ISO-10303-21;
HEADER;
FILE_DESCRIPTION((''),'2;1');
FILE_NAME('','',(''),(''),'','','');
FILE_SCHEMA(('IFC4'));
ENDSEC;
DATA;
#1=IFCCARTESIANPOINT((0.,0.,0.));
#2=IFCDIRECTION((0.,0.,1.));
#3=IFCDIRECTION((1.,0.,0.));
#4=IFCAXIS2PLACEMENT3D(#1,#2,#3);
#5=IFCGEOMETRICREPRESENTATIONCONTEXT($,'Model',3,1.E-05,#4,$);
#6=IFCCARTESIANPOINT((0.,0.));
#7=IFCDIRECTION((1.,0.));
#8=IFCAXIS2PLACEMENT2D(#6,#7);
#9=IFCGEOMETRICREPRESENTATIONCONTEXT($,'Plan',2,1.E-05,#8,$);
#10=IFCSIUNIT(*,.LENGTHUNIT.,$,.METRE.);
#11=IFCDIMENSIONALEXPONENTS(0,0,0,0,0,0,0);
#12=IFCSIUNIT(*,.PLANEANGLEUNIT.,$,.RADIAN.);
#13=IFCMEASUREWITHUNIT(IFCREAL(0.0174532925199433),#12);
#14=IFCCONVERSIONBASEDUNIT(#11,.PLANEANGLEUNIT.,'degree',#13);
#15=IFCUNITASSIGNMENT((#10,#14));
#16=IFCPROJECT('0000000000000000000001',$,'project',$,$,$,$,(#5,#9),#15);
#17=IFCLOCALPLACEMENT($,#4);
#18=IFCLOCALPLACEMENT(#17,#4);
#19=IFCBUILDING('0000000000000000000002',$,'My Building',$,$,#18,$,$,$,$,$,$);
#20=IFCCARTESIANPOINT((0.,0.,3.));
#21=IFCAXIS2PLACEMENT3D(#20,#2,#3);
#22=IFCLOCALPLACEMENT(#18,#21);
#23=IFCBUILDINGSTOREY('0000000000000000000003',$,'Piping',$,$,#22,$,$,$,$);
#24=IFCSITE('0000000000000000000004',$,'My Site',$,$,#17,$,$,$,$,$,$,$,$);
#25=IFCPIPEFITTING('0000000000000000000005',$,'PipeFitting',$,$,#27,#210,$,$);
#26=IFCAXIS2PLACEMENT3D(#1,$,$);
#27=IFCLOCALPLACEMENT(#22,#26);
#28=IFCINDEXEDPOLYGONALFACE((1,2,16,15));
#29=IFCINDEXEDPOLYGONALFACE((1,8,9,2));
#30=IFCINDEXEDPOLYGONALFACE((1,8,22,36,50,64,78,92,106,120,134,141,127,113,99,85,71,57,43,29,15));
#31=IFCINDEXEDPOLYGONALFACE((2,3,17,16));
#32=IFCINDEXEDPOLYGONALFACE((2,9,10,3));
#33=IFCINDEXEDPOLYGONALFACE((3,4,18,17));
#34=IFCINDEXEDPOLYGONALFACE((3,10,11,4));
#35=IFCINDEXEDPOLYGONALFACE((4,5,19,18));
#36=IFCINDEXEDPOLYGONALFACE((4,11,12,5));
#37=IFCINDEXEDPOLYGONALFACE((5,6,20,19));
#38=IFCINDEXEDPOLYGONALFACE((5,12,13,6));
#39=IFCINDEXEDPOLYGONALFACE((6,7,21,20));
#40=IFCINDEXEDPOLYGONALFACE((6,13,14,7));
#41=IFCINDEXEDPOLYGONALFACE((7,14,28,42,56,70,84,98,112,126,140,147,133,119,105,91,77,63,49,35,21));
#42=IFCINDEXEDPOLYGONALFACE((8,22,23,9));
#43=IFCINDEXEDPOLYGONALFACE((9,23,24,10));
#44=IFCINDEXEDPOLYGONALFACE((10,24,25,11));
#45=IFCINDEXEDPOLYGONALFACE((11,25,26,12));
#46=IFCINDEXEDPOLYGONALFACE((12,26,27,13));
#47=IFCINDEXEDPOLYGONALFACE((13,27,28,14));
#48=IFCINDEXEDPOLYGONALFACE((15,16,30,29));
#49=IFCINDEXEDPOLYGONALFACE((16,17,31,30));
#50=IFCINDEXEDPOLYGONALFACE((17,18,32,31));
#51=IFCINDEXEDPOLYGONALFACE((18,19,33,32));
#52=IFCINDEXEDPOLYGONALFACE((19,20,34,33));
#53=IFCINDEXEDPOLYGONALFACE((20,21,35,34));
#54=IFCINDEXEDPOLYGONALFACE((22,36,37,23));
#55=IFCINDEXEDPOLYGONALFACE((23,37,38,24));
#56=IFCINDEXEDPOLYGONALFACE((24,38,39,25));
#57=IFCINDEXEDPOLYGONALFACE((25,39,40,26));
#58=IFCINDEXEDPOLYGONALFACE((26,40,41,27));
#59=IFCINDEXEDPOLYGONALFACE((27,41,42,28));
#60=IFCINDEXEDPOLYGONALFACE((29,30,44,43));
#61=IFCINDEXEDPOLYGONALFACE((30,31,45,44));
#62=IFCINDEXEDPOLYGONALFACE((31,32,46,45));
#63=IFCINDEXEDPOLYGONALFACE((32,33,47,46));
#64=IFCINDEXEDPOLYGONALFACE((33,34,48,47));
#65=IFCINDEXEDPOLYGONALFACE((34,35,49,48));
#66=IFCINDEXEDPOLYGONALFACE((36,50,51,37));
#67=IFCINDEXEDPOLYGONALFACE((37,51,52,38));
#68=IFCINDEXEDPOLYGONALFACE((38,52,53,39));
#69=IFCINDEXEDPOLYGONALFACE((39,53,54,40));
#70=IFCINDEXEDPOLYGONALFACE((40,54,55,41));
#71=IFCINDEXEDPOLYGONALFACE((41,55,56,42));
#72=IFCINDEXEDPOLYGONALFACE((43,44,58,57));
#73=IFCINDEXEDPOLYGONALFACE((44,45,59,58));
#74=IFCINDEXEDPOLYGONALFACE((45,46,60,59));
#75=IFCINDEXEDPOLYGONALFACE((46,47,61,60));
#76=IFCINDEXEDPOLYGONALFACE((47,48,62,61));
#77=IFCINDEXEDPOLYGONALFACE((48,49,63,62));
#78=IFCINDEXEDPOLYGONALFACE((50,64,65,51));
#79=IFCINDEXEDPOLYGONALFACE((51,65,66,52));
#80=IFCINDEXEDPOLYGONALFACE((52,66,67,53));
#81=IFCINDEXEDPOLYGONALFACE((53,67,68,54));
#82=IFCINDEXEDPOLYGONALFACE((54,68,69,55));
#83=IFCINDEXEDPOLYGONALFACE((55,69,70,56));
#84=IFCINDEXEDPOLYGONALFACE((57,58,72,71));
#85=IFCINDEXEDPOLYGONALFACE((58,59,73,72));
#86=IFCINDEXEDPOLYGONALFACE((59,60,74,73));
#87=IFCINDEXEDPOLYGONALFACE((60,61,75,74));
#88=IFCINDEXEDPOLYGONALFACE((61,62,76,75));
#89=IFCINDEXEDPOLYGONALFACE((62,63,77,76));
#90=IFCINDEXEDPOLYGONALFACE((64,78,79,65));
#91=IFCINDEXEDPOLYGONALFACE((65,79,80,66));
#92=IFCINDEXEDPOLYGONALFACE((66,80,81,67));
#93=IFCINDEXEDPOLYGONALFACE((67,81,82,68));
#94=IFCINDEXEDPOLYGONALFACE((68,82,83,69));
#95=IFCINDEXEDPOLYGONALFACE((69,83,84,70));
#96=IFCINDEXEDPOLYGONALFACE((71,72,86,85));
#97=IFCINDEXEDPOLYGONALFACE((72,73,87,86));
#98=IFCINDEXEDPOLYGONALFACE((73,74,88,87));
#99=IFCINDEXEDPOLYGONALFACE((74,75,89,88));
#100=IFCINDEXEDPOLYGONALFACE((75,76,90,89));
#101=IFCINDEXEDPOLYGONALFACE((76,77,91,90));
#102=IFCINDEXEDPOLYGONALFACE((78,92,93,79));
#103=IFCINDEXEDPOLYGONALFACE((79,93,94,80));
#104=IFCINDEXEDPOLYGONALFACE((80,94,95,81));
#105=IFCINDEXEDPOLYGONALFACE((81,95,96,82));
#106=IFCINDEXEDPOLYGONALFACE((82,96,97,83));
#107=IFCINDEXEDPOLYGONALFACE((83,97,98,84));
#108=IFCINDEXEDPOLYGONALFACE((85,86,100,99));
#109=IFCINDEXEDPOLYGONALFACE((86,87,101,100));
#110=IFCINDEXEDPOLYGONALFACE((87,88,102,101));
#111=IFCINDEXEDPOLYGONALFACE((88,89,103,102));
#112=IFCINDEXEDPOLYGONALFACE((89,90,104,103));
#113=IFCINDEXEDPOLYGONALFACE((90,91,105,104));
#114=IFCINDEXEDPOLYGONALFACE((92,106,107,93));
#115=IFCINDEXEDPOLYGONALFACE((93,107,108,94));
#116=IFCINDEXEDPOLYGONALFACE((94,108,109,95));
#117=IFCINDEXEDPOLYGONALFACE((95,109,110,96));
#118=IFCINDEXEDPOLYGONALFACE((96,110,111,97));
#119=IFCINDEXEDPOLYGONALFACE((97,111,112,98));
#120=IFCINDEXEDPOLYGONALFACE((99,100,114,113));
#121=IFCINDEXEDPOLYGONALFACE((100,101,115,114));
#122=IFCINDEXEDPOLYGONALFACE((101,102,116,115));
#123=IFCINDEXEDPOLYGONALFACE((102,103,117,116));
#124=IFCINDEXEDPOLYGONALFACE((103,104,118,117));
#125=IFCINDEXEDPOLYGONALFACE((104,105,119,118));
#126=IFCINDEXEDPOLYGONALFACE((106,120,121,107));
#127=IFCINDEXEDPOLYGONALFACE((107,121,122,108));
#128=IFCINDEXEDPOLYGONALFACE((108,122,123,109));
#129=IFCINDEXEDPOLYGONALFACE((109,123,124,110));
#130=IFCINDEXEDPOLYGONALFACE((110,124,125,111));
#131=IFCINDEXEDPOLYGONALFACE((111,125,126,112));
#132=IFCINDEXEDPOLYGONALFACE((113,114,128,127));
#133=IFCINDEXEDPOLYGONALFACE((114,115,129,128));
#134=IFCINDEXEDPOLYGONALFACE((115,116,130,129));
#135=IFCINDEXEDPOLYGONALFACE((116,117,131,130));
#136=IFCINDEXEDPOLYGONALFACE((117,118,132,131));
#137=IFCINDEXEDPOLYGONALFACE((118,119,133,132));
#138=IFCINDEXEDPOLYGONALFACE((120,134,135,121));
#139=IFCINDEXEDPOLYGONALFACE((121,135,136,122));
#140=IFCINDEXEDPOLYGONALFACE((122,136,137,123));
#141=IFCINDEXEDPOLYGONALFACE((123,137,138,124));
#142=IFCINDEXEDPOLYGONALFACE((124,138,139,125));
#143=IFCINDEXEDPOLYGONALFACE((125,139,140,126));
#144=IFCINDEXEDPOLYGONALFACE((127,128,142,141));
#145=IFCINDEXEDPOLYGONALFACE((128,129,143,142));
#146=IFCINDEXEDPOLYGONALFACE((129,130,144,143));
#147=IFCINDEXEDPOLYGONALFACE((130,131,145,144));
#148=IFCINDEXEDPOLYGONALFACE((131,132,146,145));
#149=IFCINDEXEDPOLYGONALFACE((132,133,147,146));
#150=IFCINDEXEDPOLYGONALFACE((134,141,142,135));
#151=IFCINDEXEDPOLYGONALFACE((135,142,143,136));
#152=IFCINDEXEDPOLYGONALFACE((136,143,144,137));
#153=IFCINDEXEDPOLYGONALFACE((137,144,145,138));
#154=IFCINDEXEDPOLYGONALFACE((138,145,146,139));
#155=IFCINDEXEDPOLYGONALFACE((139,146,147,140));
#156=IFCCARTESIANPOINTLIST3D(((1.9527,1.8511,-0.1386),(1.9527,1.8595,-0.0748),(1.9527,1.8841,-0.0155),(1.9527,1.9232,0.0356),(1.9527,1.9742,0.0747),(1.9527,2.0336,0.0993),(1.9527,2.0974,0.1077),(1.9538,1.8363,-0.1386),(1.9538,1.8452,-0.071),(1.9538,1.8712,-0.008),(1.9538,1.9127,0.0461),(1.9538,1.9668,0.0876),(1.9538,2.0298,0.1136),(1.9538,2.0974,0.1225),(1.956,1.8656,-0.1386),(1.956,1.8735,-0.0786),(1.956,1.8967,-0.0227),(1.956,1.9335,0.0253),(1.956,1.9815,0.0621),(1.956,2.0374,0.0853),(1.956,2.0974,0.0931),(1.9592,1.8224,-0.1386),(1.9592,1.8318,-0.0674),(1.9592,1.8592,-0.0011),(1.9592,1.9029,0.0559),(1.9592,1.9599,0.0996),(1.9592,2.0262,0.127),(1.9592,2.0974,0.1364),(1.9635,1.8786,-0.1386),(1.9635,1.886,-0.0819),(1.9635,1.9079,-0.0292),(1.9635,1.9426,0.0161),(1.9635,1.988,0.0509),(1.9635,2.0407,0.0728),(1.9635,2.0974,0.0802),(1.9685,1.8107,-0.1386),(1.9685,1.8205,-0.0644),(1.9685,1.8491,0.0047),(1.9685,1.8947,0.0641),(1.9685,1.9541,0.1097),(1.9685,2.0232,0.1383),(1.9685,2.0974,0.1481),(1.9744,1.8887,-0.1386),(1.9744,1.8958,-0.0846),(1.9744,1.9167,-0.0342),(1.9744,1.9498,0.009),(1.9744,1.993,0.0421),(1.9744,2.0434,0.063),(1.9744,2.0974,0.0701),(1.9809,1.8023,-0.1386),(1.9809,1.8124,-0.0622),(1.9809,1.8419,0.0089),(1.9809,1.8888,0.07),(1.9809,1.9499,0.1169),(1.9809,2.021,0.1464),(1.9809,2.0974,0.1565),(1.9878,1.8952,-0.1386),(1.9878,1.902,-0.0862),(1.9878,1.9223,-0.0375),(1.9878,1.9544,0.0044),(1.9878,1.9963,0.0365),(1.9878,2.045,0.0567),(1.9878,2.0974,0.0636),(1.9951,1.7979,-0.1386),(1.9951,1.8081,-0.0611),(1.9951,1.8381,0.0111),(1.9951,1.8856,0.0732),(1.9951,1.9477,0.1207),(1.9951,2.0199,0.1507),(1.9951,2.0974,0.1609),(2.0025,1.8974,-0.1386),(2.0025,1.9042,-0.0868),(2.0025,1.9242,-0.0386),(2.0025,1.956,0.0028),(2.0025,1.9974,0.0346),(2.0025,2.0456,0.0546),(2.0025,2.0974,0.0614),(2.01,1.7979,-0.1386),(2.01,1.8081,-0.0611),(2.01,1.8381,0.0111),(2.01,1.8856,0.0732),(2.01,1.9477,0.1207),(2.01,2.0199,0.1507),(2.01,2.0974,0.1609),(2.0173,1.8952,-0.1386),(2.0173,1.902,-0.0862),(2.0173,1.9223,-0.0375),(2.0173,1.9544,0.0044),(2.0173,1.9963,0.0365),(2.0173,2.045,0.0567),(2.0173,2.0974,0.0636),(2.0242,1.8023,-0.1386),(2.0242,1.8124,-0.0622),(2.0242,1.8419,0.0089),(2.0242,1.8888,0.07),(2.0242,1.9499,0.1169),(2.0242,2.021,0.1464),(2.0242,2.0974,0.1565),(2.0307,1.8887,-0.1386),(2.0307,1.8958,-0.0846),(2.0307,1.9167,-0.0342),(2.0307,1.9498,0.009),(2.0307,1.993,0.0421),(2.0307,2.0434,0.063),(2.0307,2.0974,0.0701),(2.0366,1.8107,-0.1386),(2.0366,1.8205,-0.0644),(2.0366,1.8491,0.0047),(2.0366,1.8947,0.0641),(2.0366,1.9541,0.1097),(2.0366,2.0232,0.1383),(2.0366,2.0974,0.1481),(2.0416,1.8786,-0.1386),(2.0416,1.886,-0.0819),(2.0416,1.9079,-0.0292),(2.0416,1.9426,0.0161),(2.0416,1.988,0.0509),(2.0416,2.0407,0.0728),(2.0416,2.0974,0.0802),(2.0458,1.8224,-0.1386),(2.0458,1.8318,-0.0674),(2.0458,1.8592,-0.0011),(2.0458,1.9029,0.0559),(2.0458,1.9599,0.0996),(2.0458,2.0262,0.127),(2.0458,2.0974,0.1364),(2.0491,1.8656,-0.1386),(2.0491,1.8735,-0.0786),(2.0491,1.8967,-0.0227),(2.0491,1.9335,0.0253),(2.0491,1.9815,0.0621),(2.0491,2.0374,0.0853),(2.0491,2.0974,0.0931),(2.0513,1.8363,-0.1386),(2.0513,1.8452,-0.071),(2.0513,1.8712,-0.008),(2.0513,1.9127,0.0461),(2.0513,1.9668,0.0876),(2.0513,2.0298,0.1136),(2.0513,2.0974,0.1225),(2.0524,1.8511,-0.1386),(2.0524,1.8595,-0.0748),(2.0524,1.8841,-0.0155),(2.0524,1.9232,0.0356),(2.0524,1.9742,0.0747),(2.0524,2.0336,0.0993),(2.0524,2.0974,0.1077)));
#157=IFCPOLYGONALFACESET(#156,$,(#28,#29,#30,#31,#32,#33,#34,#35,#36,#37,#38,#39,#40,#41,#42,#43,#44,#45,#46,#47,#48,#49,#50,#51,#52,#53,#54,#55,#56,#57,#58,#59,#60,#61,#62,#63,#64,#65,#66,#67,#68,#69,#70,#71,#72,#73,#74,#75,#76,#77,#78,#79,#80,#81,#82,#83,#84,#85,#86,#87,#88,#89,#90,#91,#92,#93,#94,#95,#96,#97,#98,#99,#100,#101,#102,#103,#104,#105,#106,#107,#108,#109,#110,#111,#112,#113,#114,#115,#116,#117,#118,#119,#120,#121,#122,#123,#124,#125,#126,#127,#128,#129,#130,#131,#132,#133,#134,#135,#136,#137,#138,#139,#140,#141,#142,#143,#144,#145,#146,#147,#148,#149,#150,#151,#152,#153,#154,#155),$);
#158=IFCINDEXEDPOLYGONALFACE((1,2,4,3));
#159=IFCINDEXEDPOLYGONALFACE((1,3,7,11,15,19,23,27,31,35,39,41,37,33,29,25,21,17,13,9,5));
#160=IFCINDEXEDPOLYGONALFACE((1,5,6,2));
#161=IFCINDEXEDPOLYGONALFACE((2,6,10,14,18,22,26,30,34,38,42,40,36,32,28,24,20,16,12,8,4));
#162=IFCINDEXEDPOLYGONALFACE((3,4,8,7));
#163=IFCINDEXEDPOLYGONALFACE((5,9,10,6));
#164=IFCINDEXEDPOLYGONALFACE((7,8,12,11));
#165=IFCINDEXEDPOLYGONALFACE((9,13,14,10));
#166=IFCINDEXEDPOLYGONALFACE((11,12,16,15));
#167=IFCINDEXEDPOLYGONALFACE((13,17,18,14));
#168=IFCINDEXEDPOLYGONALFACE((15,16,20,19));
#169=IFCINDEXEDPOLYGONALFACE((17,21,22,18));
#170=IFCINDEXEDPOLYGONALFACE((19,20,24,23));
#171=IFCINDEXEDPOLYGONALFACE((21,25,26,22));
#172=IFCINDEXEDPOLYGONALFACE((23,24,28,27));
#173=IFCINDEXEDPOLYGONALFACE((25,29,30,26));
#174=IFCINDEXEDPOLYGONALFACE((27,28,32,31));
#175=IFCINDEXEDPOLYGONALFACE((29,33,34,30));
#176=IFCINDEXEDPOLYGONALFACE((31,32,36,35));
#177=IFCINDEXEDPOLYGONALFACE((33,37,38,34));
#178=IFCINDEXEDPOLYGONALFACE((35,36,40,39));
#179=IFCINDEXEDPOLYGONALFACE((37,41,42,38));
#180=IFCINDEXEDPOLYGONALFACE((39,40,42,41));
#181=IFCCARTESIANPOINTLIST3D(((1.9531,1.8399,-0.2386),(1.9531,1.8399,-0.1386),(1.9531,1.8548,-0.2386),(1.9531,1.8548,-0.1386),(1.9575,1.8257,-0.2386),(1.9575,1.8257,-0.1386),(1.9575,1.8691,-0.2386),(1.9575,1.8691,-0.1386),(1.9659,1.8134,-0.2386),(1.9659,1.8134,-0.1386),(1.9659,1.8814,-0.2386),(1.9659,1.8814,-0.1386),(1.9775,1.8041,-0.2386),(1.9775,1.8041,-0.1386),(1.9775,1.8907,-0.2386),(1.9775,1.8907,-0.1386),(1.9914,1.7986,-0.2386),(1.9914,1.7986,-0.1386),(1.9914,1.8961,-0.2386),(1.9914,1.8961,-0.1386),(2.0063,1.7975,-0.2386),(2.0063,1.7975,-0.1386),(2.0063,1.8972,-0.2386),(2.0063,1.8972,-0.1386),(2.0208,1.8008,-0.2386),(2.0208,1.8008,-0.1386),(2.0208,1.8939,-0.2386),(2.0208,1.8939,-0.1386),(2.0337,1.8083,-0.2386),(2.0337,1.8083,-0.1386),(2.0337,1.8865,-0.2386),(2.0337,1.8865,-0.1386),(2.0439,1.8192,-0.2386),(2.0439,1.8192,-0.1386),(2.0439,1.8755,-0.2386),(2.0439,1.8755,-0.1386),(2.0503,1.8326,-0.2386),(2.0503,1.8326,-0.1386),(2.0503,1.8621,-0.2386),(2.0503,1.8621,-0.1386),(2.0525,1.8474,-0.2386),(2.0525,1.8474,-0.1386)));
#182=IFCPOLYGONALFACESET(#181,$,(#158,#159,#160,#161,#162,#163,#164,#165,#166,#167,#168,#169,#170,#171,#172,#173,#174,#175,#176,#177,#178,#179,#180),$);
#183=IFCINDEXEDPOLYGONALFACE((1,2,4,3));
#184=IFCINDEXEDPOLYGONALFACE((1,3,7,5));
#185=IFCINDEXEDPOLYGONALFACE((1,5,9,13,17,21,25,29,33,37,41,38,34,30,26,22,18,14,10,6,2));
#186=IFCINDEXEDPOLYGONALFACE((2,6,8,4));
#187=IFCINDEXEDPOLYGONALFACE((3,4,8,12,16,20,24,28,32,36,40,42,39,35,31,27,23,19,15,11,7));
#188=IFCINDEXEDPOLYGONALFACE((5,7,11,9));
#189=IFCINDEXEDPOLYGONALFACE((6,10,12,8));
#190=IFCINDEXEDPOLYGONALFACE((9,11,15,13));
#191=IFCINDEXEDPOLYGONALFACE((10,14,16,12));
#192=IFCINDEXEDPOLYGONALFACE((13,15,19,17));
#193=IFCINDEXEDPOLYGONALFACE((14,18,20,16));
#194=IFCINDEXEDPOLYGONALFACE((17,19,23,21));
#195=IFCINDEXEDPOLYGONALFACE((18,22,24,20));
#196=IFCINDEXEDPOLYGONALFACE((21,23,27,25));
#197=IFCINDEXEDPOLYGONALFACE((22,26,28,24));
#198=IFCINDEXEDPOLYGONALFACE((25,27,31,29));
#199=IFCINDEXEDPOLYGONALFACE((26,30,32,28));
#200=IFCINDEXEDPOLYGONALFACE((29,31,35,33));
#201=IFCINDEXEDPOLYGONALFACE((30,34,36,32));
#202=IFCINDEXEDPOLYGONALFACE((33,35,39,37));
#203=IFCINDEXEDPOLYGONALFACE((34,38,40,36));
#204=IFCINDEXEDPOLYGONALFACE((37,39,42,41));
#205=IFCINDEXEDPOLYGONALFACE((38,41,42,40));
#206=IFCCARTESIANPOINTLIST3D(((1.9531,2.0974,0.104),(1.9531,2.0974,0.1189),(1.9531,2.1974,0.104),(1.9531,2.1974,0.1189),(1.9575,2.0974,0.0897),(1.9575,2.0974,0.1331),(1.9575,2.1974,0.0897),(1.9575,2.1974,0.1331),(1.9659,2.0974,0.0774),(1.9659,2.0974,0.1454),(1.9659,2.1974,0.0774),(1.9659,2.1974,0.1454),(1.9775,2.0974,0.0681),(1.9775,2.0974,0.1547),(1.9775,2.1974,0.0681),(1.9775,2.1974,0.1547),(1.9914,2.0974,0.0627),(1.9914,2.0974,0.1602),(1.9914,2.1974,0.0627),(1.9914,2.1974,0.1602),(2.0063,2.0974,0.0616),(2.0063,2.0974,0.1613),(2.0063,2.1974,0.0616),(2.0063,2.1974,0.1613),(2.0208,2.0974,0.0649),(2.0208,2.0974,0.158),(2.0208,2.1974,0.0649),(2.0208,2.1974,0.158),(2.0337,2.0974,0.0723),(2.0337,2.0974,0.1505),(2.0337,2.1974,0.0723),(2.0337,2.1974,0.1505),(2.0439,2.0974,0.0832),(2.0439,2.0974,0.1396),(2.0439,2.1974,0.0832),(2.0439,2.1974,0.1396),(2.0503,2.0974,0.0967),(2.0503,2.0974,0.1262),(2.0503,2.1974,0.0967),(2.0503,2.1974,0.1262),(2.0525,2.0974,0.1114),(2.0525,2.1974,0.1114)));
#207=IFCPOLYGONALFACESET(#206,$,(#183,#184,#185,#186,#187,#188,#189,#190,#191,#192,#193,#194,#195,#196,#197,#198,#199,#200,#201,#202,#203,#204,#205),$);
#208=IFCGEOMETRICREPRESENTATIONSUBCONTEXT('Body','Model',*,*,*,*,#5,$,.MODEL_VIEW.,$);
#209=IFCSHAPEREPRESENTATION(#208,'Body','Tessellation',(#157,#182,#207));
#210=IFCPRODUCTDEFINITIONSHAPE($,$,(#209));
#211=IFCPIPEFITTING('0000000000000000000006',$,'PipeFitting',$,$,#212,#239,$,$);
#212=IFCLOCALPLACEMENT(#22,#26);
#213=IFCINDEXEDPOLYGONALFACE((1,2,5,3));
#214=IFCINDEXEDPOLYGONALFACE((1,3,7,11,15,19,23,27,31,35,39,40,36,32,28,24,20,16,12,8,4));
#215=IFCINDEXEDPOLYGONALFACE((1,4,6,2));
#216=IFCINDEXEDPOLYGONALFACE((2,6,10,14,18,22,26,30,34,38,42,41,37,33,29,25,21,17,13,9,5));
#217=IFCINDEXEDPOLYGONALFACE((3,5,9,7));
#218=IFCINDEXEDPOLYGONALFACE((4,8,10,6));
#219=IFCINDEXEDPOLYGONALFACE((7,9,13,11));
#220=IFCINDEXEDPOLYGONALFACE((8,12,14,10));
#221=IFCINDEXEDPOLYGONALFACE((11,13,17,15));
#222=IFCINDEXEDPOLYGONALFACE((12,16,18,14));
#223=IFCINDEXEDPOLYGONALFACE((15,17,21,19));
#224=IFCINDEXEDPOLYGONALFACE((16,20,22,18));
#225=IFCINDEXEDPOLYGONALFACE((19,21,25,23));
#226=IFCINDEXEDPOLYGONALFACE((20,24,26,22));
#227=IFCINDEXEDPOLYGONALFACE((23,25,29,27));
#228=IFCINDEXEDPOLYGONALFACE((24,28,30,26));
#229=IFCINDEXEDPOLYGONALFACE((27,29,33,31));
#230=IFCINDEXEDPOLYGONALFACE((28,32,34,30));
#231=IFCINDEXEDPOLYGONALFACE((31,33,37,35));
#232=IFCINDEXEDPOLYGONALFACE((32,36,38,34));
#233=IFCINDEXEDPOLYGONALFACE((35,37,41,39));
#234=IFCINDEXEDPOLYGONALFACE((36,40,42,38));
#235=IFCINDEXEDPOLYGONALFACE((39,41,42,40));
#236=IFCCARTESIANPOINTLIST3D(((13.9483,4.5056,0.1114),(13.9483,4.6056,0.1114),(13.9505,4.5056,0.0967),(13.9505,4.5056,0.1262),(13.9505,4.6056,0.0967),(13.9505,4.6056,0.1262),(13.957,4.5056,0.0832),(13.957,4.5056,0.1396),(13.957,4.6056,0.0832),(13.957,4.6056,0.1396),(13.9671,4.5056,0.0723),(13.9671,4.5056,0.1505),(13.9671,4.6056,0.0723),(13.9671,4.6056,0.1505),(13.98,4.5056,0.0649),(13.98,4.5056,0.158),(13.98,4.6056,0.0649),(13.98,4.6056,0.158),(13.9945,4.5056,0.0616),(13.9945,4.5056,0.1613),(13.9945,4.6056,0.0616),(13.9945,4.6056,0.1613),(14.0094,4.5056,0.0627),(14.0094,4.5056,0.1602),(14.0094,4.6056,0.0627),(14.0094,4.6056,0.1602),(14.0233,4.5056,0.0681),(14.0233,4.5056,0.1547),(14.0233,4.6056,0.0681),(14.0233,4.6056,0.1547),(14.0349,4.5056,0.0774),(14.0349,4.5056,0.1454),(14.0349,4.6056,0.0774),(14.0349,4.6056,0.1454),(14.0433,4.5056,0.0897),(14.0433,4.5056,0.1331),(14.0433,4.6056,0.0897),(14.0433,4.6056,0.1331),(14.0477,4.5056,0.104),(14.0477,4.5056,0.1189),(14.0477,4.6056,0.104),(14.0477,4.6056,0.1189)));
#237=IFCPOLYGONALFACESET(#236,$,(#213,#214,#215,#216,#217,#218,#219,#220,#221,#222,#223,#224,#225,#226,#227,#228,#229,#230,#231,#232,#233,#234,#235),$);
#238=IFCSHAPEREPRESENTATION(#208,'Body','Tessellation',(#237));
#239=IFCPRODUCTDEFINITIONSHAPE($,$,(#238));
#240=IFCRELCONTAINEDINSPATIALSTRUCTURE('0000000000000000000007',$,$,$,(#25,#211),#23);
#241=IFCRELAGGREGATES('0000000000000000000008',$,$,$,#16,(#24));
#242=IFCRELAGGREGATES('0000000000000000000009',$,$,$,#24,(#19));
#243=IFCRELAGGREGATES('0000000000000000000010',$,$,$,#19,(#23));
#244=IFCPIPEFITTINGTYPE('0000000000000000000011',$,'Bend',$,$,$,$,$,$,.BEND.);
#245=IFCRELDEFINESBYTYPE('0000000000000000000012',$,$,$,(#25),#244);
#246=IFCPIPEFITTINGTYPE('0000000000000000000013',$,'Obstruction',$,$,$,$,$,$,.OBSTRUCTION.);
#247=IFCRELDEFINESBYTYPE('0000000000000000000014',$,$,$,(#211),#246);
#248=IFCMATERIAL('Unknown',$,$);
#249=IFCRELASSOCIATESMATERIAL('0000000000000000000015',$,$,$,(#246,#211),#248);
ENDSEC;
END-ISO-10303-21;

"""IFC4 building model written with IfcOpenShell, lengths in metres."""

from ifc_helpers import new_model, entity, si_unit, converted_unit, frame, origin_with_axes, origin_2d_with_axis, place, context, subcontext, project, spatial, circle, extrude, source, transform, mapped, material, material_profile, profile_set, profile_usage, type_object, type_shapes, element, save


model = new_model("IFC4")

# Units and contexts
model_context = context("Model", 3, precision=1e-05, world=origin_with_axes())
plan_context = context("Plan", 2, precision=1e-05, world=origin_2d_with_axis())
body_context = subcontext(model_context, "Body", "Model", "MODEL_VIEW")
ifc_project = project(units=[si_unit("LENGTHUNIT", "METRE"), converted_unit("PLANEANGLEUNIT", "degree", entity("IfcReal", 0.0174532925199433), si_unit("PLANEANGLEUNIT", "RADIAN"), dimensions=[0, 0, 0, 0, 0, 0, 0])], contexts=[model_context, plan_context])

# Site, building, storey
site_placement = place(None, origin_with_axes())
site = spatial("IfcSite", under=ifc_project, at=site_placement, Name="My Site")
building_placement = place(site_placement, origin_with_axes())
building = spatial("IfcBuilding", under=site, at=building_placement, Name="My Building")
storey_placement = place(building_placement, frame((0.0, 0.0, 3.0), z_axis=(0.0, 0.0, 1.0), x_axis=(1.0, 0.0, 0.0)))
storey = spatial("IfcBuildingStorey", under=building, at=storey_placement, Name="Piping")

# Shared definitions
ifc_material = material(Name="Unknown")

# Pipe fittings
pipe_fitting_type_1 = type_object("IfcPipeFittingType", Name="Bend", PredefinedType="BEND")
shared_shape = source(origin_with_axes(), body_context, "Body", "SolidModel", [
    entity("IfcSweptDiskSolid", entity("IfcIndexedPolyCurve", entity("IfcCartesianPointList3D", [[0.0, 0.0, -0.1], [0.0, -0.0732, -0.2768], [0.0, -0.25, -0.35]]), [entity("IfcArcIndex", [1, 2, 3])]), 0.05),
    extrude(circle(Radius=0.05), origin_with_axes(), (0.0, 0.0, -1.0), 0.1),
    extrude(circle(Radius=0.05), frame((0.0, -0.25, -0.35), z_axis=(0.0, -1.0, 0.0), x_axis=(1.0, 0.0, 0.0)), (0.0, 0.0, 1.0), 0.1),
])
type_shapes(pipe_fitting_type_1, [shared_shape])
for number, where, z_axis, x_axis, name in (
    (1, (2.0025, 1.8474, -0.2386), (0.0, 0.0, -1.0), (1.0, 0.0, 0.0), "PipeFitting"),
):
    element("IfcPipeFitting", number, at=place(storey_placement, frame(where, z_axis=z_axis, x_axis=x_axis)), inside=storey, type_object=pipe_fitting_type_1, Name=name, context=body_context, shape_type="MappedRepresentation", body=[
        mapped(shared_shape, transform((0.0, 0.0, 0.0), x_axis=(1.0, 0.0, 0.0), y_axis=(0.0, 1.0, 0.0), z_axis=(0.0, 0.0, 1.0), scale=1.0)),
    ])
ifc_material_profile_1 = material_profile(ifc_material, circle(Radius=0.05))
ifc_profile_set_1 = profile_set([ifc_material_profile_1])
ifc_profile_usage_1 = profile_usage(ifc_profile_set_1, cardinal=16)
pipe_fitting_type_2 = type_object("IfcPipeFittingType", Name="Obstruction", PredefinedType="OBSTRUCTION", material=ifc_profile_set_1)
pipe_fitting_1_placement = place(storey_placement, frame((13.9983, 4.5056, 0.1114), z_axis=(0.0, 1.0, 0.0), x_axis=(-1.0, 0.0, 0.0)))
element("IfcPipeFitting", 2, at=pipe_fitting_1_placement, inside=storey, type_object=pipe_fitting_type_2, material=ifc_profile_usage_1, Name="PipeFitting", context=body_context, shape_type="SweptSolid", body=[
    extrude(circle(Radius=0.05), origin_with_axes(), (0.0, 0.0, 1.0), 0.1),
])

save(model, "model.ifc")
